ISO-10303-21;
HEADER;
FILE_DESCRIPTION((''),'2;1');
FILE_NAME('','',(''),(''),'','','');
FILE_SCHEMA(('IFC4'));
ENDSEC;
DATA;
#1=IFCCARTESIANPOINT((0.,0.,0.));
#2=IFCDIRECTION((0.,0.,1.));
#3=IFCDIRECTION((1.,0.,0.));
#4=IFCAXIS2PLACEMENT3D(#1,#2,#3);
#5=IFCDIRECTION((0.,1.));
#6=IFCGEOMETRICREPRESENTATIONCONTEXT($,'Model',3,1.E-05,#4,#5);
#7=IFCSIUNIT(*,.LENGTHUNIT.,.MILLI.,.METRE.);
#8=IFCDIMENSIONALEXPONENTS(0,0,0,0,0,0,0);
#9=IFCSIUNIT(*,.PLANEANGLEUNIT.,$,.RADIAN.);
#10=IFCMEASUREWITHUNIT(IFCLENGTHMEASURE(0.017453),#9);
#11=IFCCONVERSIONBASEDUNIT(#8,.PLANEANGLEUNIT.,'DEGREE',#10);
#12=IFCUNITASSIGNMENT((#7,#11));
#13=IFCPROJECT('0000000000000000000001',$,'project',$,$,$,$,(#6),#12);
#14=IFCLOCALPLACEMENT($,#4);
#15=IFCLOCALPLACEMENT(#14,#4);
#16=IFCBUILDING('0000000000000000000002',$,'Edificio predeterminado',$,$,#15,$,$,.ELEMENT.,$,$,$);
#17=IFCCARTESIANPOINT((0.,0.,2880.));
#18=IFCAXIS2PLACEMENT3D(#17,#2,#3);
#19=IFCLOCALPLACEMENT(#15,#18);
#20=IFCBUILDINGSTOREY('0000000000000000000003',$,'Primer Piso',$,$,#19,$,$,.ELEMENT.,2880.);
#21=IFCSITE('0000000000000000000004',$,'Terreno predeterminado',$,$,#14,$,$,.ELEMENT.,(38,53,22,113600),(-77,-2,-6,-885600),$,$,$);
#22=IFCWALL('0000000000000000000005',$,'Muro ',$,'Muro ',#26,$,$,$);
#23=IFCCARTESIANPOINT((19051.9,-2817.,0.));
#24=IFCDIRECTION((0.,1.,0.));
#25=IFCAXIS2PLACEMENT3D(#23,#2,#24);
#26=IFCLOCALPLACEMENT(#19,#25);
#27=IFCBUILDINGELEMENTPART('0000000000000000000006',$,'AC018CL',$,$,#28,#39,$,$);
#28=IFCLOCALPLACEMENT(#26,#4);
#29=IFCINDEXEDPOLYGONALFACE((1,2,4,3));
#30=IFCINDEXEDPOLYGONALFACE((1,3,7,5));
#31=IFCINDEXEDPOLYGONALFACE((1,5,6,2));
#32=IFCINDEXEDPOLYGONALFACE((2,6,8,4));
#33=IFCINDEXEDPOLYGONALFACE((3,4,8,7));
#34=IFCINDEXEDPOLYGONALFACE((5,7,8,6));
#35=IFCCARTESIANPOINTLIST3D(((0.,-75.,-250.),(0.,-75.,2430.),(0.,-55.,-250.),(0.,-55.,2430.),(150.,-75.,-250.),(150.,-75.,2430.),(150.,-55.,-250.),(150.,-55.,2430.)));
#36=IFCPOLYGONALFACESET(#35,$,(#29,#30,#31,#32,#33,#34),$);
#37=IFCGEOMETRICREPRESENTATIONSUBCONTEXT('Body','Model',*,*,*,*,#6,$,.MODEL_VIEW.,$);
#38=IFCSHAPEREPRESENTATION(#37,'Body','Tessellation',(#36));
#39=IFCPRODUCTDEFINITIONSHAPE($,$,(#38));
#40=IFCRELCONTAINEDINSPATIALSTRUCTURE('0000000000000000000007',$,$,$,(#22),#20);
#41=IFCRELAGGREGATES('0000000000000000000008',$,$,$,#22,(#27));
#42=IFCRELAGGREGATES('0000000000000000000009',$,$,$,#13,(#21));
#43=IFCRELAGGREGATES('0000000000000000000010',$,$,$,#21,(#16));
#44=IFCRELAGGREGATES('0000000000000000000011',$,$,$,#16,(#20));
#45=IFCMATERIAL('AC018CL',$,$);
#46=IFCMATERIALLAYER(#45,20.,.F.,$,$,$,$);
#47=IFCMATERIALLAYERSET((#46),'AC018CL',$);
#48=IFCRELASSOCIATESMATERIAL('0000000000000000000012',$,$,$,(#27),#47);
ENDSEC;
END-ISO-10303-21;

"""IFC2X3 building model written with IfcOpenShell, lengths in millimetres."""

from ifc_helpers import new_model, entity, si_unit, converted_unit, direction, frame, origin_with_axes, place, context, subcontext, project, spatial, polyline, outline, extrude, clip, bounded_halfspace, material, layer, layer_set, layer_usage, element, aggregate, save


model = new_model("IFC2X3")

# Units and contexts
model_context = context("Model", 3, precision=1e-05, world=origin_with_axes(), true_north=direction((0.0, 1.0)))
body_context = subcontext(model_context, "Body", "Model", "MODEL_VIEW")
ifc_project = project(units=[si_unit("LENGTHUNIT", "METRE", prefix="MILLI"), converted_unit("PLANEANGLEUNIT", "DEGREE", entity("IfcLengthMeasure", 0.017453), si_unit("PLANEANGLEUNIT", "RADIAN"), dimensions=[0, 0, 0, 0, 0, 0, 0])], contexts=[model_context])

# Site, building, storey
site_placement = place(None, origin_with_axes())
site = spatial("IfcSite", under=ifc_project, at=site_placement, Name="Terreno predeterminado", CompositionType="ELEMENT", RefLatitude=(38, 53, 22, 113600), RefLongitude=(-77, -2, -6, -885600))
building_placement = place(site_placement, origin_with_axes())
building = spatial("IfcBuilding", under=site, at=building_placement, Name="Edificio predeterminado", CompositionType="ELEMENT")
storey_placement = place(building_placement, frame((0.0, 0.0, 2880.0), z_axis=(0.0, 0.0, 1.0), x_axis=(1.0, 0.0, 0.0)))
storey = spatial("IfcBuildingStorey", under=building, at=storey_placement, Name="Primer Piso", CompositionType="ELEMENT", Elevation=2880.0)

# Wall, building element part
wall_1_placement = place(storey_placement, frame((19051.9, -2817.0, 0.0), z_axis=(0.0, 0.0, 1.0), x_axis=(0.0, 1.0, 0.0)))
wall_1 = element("IfcWall", 1, at=wall_1_placement, inside=storey, Name="Muro ", ObjectType="Muro ")
ifc_material_1 = material(Name="AC018CL")
ifc_layer_1 = layer(ifc_material_1, 20.0, ventilated=False)
ifc_layer_set_1 = layer_set([ifc_layer_1], Name="AC018CL")
ifc_layer_usage_1 = layer_usage(ifc_layer_set_1, "AXIS2", "NEGATIVE", 55.0)
building_element_part_1_placement = place(wall_1_placement, origin_with_axes())
building_element_part_1 = element("IfcBuildingElementPart", 2, at=building_element_part_1_placement, material=ifc_layer_usage_1, Name="AC018CL", context=body_context, shape_type="Clipping", body=[
    clip(clip(extrude(outline(polyline([(150.0, -55.0), (150.0, -75.0), (0.0, -75.0), (0.0, -55.0), (150.0, -55.0)])), frame((0.0, 0.0, -250.0), z_axis=(0.0, 0.0, 1.0), x_axis=(1.0, 0.0, 0.0)), (0.0, 0.0, 1.0), 2680.0), bounded_halfspace(frame((0.0, 0.0, -250.0), z_axis=(0.0, 0.0, 1.0), x_axis=(1.0, 0.0, 0.0)), True, origin_with_axes(), polyline([(-150.0, -150.0), (375.0, -150.0), (375.0, 150.0), (-150.0, 150.0), (-150.0, -150.0)]))), bounded_halfspace(frame((0.0, 0.0, 2430.0), z_axis=(0.0, 0.0, 1.0), x_axis=(1.0, 0.0, 0.0)), False, origin_with_axes(), polyline([(-150.0, -150.0), (375.0, -150.0), (375.0, 150.0), (-150.0, 150.0), (-150.0, -150.0)]))),
])
aggregate(wall_1, [building_element_part_1])

save(model, "model.ifc")
